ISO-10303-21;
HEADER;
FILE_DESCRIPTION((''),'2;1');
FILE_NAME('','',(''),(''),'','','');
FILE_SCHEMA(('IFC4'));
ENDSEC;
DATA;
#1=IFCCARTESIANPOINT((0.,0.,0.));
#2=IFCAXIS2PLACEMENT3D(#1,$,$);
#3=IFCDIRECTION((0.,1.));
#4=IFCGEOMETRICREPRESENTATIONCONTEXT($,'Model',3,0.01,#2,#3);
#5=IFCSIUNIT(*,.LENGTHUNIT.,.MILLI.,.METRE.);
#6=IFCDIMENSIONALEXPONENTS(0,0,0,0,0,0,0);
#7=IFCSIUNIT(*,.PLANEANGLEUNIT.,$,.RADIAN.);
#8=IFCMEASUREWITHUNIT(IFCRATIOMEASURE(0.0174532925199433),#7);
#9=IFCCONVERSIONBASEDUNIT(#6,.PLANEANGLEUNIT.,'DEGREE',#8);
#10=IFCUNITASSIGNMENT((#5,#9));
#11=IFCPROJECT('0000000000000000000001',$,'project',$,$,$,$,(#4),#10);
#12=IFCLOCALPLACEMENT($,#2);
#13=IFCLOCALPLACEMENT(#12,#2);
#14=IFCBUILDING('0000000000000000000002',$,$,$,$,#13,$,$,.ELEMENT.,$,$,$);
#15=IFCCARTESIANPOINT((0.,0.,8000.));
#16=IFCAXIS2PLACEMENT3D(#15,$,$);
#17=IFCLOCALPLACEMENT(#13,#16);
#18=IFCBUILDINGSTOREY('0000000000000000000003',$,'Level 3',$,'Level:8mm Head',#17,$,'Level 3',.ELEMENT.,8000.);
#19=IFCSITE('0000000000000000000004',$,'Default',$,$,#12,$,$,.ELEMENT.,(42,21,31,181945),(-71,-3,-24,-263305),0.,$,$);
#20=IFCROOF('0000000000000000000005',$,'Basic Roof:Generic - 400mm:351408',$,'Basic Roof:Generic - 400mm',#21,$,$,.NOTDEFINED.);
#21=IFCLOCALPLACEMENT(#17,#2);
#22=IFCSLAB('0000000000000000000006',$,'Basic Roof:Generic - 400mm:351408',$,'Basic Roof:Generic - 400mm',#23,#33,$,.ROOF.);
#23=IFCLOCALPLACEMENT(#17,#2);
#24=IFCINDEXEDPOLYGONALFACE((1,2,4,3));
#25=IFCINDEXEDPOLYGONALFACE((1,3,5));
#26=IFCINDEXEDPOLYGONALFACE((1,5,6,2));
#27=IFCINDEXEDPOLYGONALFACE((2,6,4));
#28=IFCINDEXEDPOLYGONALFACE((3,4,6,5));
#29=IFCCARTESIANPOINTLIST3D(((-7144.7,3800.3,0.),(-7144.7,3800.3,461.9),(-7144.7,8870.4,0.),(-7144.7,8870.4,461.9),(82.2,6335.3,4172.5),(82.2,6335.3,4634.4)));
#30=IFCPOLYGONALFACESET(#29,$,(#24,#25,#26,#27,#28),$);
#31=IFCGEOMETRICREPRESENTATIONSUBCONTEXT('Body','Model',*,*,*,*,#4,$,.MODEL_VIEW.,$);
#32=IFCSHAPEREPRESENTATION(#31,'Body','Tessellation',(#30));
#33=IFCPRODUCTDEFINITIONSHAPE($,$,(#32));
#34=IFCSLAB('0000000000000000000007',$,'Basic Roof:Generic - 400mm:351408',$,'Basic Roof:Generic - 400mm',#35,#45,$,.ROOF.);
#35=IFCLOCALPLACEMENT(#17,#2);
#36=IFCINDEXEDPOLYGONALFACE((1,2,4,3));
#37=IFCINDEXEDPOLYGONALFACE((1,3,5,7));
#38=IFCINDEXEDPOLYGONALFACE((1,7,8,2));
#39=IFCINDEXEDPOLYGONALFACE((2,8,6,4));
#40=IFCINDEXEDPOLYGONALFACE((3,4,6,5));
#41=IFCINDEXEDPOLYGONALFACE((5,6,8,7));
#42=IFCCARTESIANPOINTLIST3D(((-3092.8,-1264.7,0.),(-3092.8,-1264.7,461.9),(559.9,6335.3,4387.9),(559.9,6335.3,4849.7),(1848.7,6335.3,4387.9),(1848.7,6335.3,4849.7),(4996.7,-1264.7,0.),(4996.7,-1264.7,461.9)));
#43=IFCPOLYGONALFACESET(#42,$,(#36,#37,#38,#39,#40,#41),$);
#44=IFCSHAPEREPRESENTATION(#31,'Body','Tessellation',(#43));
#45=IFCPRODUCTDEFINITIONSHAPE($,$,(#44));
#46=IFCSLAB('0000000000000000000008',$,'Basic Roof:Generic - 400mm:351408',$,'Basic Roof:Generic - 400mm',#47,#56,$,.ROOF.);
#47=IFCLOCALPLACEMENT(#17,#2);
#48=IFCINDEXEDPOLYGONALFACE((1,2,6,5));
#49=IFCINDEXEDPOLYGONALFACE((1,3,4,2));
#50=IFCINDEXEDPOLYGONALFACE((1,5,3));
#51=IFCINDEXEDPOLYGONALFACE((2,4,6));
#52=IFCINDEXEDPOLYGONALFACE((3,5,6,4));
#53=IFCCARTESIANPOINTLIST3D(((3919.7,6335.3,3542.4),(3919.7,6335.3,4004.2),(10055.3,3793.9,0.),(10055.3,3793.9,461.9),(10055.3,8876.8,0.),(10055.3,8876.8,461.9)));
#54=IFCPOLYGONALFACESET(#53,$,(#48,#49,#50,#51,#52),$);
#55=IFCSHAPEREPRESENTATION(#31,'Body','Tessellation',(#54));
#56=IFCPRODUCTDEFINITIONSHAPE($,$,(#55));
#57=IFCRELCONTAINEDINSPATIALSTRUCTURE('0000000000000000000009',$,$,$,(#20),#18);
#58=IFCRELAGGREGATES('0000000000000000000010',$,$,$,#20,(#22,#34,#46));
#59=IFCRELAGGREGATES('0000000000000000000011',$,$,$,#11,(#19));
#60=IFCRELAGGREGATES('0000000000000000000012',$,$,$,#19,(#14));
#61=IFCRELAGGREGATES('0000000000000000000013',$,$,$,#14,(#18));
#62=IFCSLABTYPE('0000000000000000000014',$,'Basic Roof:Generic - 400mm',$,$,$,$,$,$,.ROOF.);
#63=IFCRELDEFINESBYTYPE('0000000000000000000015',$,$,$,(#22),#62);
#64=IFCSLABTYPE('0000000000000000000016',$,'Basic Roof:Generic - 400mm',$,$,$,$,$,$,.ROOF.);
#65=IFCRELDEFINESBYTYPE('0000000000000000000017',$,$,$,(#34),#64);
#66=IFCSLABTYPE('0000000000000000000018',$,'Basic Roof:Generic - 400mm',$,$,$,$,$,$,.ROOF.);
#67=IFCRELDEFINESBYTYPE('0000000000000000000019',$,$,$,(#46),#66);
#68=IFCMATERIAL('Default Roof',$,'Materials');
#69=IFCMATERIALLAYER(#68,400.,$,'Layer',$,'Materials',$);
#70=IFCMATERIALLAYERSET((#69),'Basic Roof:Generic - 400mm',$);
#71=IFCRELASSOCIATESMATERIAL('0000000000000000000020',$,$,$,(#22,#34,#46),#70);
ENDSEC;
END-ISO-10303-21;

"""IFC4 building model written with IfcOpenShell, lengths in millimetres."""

from ifc_helpers import new_model, entity, si_unit, converted_unit, direction, frame, origin, place, context, subcontext, project, spatial, polyline, outline, extrude, material, layer, layer_set, type_object, element, aggregate, save


model = new_model("IFC4")

# Units and contexts
model_context = context("Model", 3, precision=0.01, world=origin(), true_north=direction((0.0, 1.0)))
body_context = subcontext(model_context, "Body", "Model", "MODEL_VIEW")
ifc_project = project(units=[si_unit("LENGTHUNIT", "METRE", prefix="MILLI"), converted_unit("PLANEANGLEUNIT", "DEGREE", entity("IfcRatioMeasure", 0.0174532925199433), si_unit("PLANEANGLEUNIT", "RADIAN"), dimensions=[0, 0, 0, 0, 0, 0, 0])], contexts=[model_context])

# Site, building, storey
site_placement = place(None, origin())
site = spatial("IfcSite", under=ifc_project, at=site_placement, Name="Default", CompositionType="ELEMENT", RefLatitude=(42, 21, 31, 181945), RefLongitude=(-71, -3, -24, -263305), RefElevation=0.0)
building_placement = place(site_placement, origin())
building = spatial("IfcBuilding", under=site, at=building_placement, CompositionType="ELEMENT")
storey_placement = place(building_placement, frame((0.0, 0.0, 8000.0)))
storey = spatial("IfcBuildingStorey", under=building, at=storey_placement, Name="Level 3", ObjectType="Level:8mm Head", LongName="Level 3", CompositionType="ELEMENT", Elevation=8000.0)

# Roof, slabs
roof_placement = place(storey_placement, frame((-7144.7, -1264.7, 0.0)))
roof = element("IfcRoof", 1, at=roof_placement, inside=storey, Name="Basic Roof:Generic - 400mm:351408", ObjectType="Basic Roof:Generic - 400mm", PredefinedType="NOTDEFINED")
ifc_material = material(Name="Default Roof", Category="Materials")
ifc_layer = layer(ifc_material, 400.0, Name="Layer", Category="Materials")
ifc_layer_set = layer_set([ifc_layer], Name="Basic Roof:Generic - 400mm")
slab_type_1 = type_object("IfcSlabType", Name="Basic Roof:Generic - 400mm", PredefinedType="ROOF")
slab_1_placement = place(roof_placement, origin())
slab_1 = element("IfcSlab", 2, at=slab_1_placement, type_object=slab_type_1, material=ifc_layer_set, Name="Basic Roof:Generic - 400mm:351408", ObjectType="Basic Roof:Generic - 400mm", PredefinedType="ROOF", context=body_context, shape_type="SweptSolid", body=[
    extrude(outline(polyline([(-4172.5, 2535.1), (-4172.5, -2535.1), (4172.5, 0.0), (-4172.5, 2535.1)])), frame((3613.5, 7600.0, 2086.2), z_axis=(-0.5, 0.0, 0.866025), x_axis=(0.866025, 0.0, 0.5)), (0.5, 0.0, 0.866025), 461.9),
])
slab_type_2 = type_object("IfcSlabType", Name="Basic Roof:Generic - 400mm", PredefinedType="ROOF")
slab_2_placement = place(roof_placement, origin())
slab_2 = element("IfcSlab", 3, at=slab_2_placement, type_object=slab_type_2, material=ifc_layer_set, Name="Basic Roof:Generic - 400mm:351408", ObjectType="Basic Roof:Generic - 400mm", PredefinedType="ROOF", context=body_context, shape_type="SweptSolid", body=[
    extrude(outline(polyline([(-4044.7, -4387.9), (4044.7, -4387.9), (896.7, 4387.9), (-392.0, 4387.9), (-4044.7, -4387.9)])), frame((8096.7, 3800.0, 2193.9), z_axis=(0.0, -0.5, 0.866025), x_axis=(1.0, 0.0, 0.0)), (0.0, 0.5, 0.866025), 461.9),
])
slab_type_3 = type_object("IfcSlabType", Name="Basic Roof:Generic - 400mm", PredefinedType="ROOF")
slab_3_placement = place(roof_placement, origin())
slab_3 = element("IfcSlab", 4, at=slab_3_placement, type_object=slab_type_3, material=ifc_layer_set, Name="Basic Roof:Generic - 400mm:351408", ObjectType="Basic Roof:Generic - 400mm", PredefinedType="ROOF", context=body_context, shape_type="SweptSolid", body=[
    extrude(outline(polyline([(3542.4, -2541.4), (3542.4, 2541.4), (-3542.4, 0.0), (3542.4, -2541.4)])), frame((14132.2, 7600.0, 1771.2), z_axis=(0.5, 0.0, 0.866025), x_axis=(0.866025, 0.0, -0.5)), (-0.5, 0.0, 0.866025), 461.9),
])
aggregate(roof, [slab_1, slab_2, slab_3])

save(model, "model.ifc")
